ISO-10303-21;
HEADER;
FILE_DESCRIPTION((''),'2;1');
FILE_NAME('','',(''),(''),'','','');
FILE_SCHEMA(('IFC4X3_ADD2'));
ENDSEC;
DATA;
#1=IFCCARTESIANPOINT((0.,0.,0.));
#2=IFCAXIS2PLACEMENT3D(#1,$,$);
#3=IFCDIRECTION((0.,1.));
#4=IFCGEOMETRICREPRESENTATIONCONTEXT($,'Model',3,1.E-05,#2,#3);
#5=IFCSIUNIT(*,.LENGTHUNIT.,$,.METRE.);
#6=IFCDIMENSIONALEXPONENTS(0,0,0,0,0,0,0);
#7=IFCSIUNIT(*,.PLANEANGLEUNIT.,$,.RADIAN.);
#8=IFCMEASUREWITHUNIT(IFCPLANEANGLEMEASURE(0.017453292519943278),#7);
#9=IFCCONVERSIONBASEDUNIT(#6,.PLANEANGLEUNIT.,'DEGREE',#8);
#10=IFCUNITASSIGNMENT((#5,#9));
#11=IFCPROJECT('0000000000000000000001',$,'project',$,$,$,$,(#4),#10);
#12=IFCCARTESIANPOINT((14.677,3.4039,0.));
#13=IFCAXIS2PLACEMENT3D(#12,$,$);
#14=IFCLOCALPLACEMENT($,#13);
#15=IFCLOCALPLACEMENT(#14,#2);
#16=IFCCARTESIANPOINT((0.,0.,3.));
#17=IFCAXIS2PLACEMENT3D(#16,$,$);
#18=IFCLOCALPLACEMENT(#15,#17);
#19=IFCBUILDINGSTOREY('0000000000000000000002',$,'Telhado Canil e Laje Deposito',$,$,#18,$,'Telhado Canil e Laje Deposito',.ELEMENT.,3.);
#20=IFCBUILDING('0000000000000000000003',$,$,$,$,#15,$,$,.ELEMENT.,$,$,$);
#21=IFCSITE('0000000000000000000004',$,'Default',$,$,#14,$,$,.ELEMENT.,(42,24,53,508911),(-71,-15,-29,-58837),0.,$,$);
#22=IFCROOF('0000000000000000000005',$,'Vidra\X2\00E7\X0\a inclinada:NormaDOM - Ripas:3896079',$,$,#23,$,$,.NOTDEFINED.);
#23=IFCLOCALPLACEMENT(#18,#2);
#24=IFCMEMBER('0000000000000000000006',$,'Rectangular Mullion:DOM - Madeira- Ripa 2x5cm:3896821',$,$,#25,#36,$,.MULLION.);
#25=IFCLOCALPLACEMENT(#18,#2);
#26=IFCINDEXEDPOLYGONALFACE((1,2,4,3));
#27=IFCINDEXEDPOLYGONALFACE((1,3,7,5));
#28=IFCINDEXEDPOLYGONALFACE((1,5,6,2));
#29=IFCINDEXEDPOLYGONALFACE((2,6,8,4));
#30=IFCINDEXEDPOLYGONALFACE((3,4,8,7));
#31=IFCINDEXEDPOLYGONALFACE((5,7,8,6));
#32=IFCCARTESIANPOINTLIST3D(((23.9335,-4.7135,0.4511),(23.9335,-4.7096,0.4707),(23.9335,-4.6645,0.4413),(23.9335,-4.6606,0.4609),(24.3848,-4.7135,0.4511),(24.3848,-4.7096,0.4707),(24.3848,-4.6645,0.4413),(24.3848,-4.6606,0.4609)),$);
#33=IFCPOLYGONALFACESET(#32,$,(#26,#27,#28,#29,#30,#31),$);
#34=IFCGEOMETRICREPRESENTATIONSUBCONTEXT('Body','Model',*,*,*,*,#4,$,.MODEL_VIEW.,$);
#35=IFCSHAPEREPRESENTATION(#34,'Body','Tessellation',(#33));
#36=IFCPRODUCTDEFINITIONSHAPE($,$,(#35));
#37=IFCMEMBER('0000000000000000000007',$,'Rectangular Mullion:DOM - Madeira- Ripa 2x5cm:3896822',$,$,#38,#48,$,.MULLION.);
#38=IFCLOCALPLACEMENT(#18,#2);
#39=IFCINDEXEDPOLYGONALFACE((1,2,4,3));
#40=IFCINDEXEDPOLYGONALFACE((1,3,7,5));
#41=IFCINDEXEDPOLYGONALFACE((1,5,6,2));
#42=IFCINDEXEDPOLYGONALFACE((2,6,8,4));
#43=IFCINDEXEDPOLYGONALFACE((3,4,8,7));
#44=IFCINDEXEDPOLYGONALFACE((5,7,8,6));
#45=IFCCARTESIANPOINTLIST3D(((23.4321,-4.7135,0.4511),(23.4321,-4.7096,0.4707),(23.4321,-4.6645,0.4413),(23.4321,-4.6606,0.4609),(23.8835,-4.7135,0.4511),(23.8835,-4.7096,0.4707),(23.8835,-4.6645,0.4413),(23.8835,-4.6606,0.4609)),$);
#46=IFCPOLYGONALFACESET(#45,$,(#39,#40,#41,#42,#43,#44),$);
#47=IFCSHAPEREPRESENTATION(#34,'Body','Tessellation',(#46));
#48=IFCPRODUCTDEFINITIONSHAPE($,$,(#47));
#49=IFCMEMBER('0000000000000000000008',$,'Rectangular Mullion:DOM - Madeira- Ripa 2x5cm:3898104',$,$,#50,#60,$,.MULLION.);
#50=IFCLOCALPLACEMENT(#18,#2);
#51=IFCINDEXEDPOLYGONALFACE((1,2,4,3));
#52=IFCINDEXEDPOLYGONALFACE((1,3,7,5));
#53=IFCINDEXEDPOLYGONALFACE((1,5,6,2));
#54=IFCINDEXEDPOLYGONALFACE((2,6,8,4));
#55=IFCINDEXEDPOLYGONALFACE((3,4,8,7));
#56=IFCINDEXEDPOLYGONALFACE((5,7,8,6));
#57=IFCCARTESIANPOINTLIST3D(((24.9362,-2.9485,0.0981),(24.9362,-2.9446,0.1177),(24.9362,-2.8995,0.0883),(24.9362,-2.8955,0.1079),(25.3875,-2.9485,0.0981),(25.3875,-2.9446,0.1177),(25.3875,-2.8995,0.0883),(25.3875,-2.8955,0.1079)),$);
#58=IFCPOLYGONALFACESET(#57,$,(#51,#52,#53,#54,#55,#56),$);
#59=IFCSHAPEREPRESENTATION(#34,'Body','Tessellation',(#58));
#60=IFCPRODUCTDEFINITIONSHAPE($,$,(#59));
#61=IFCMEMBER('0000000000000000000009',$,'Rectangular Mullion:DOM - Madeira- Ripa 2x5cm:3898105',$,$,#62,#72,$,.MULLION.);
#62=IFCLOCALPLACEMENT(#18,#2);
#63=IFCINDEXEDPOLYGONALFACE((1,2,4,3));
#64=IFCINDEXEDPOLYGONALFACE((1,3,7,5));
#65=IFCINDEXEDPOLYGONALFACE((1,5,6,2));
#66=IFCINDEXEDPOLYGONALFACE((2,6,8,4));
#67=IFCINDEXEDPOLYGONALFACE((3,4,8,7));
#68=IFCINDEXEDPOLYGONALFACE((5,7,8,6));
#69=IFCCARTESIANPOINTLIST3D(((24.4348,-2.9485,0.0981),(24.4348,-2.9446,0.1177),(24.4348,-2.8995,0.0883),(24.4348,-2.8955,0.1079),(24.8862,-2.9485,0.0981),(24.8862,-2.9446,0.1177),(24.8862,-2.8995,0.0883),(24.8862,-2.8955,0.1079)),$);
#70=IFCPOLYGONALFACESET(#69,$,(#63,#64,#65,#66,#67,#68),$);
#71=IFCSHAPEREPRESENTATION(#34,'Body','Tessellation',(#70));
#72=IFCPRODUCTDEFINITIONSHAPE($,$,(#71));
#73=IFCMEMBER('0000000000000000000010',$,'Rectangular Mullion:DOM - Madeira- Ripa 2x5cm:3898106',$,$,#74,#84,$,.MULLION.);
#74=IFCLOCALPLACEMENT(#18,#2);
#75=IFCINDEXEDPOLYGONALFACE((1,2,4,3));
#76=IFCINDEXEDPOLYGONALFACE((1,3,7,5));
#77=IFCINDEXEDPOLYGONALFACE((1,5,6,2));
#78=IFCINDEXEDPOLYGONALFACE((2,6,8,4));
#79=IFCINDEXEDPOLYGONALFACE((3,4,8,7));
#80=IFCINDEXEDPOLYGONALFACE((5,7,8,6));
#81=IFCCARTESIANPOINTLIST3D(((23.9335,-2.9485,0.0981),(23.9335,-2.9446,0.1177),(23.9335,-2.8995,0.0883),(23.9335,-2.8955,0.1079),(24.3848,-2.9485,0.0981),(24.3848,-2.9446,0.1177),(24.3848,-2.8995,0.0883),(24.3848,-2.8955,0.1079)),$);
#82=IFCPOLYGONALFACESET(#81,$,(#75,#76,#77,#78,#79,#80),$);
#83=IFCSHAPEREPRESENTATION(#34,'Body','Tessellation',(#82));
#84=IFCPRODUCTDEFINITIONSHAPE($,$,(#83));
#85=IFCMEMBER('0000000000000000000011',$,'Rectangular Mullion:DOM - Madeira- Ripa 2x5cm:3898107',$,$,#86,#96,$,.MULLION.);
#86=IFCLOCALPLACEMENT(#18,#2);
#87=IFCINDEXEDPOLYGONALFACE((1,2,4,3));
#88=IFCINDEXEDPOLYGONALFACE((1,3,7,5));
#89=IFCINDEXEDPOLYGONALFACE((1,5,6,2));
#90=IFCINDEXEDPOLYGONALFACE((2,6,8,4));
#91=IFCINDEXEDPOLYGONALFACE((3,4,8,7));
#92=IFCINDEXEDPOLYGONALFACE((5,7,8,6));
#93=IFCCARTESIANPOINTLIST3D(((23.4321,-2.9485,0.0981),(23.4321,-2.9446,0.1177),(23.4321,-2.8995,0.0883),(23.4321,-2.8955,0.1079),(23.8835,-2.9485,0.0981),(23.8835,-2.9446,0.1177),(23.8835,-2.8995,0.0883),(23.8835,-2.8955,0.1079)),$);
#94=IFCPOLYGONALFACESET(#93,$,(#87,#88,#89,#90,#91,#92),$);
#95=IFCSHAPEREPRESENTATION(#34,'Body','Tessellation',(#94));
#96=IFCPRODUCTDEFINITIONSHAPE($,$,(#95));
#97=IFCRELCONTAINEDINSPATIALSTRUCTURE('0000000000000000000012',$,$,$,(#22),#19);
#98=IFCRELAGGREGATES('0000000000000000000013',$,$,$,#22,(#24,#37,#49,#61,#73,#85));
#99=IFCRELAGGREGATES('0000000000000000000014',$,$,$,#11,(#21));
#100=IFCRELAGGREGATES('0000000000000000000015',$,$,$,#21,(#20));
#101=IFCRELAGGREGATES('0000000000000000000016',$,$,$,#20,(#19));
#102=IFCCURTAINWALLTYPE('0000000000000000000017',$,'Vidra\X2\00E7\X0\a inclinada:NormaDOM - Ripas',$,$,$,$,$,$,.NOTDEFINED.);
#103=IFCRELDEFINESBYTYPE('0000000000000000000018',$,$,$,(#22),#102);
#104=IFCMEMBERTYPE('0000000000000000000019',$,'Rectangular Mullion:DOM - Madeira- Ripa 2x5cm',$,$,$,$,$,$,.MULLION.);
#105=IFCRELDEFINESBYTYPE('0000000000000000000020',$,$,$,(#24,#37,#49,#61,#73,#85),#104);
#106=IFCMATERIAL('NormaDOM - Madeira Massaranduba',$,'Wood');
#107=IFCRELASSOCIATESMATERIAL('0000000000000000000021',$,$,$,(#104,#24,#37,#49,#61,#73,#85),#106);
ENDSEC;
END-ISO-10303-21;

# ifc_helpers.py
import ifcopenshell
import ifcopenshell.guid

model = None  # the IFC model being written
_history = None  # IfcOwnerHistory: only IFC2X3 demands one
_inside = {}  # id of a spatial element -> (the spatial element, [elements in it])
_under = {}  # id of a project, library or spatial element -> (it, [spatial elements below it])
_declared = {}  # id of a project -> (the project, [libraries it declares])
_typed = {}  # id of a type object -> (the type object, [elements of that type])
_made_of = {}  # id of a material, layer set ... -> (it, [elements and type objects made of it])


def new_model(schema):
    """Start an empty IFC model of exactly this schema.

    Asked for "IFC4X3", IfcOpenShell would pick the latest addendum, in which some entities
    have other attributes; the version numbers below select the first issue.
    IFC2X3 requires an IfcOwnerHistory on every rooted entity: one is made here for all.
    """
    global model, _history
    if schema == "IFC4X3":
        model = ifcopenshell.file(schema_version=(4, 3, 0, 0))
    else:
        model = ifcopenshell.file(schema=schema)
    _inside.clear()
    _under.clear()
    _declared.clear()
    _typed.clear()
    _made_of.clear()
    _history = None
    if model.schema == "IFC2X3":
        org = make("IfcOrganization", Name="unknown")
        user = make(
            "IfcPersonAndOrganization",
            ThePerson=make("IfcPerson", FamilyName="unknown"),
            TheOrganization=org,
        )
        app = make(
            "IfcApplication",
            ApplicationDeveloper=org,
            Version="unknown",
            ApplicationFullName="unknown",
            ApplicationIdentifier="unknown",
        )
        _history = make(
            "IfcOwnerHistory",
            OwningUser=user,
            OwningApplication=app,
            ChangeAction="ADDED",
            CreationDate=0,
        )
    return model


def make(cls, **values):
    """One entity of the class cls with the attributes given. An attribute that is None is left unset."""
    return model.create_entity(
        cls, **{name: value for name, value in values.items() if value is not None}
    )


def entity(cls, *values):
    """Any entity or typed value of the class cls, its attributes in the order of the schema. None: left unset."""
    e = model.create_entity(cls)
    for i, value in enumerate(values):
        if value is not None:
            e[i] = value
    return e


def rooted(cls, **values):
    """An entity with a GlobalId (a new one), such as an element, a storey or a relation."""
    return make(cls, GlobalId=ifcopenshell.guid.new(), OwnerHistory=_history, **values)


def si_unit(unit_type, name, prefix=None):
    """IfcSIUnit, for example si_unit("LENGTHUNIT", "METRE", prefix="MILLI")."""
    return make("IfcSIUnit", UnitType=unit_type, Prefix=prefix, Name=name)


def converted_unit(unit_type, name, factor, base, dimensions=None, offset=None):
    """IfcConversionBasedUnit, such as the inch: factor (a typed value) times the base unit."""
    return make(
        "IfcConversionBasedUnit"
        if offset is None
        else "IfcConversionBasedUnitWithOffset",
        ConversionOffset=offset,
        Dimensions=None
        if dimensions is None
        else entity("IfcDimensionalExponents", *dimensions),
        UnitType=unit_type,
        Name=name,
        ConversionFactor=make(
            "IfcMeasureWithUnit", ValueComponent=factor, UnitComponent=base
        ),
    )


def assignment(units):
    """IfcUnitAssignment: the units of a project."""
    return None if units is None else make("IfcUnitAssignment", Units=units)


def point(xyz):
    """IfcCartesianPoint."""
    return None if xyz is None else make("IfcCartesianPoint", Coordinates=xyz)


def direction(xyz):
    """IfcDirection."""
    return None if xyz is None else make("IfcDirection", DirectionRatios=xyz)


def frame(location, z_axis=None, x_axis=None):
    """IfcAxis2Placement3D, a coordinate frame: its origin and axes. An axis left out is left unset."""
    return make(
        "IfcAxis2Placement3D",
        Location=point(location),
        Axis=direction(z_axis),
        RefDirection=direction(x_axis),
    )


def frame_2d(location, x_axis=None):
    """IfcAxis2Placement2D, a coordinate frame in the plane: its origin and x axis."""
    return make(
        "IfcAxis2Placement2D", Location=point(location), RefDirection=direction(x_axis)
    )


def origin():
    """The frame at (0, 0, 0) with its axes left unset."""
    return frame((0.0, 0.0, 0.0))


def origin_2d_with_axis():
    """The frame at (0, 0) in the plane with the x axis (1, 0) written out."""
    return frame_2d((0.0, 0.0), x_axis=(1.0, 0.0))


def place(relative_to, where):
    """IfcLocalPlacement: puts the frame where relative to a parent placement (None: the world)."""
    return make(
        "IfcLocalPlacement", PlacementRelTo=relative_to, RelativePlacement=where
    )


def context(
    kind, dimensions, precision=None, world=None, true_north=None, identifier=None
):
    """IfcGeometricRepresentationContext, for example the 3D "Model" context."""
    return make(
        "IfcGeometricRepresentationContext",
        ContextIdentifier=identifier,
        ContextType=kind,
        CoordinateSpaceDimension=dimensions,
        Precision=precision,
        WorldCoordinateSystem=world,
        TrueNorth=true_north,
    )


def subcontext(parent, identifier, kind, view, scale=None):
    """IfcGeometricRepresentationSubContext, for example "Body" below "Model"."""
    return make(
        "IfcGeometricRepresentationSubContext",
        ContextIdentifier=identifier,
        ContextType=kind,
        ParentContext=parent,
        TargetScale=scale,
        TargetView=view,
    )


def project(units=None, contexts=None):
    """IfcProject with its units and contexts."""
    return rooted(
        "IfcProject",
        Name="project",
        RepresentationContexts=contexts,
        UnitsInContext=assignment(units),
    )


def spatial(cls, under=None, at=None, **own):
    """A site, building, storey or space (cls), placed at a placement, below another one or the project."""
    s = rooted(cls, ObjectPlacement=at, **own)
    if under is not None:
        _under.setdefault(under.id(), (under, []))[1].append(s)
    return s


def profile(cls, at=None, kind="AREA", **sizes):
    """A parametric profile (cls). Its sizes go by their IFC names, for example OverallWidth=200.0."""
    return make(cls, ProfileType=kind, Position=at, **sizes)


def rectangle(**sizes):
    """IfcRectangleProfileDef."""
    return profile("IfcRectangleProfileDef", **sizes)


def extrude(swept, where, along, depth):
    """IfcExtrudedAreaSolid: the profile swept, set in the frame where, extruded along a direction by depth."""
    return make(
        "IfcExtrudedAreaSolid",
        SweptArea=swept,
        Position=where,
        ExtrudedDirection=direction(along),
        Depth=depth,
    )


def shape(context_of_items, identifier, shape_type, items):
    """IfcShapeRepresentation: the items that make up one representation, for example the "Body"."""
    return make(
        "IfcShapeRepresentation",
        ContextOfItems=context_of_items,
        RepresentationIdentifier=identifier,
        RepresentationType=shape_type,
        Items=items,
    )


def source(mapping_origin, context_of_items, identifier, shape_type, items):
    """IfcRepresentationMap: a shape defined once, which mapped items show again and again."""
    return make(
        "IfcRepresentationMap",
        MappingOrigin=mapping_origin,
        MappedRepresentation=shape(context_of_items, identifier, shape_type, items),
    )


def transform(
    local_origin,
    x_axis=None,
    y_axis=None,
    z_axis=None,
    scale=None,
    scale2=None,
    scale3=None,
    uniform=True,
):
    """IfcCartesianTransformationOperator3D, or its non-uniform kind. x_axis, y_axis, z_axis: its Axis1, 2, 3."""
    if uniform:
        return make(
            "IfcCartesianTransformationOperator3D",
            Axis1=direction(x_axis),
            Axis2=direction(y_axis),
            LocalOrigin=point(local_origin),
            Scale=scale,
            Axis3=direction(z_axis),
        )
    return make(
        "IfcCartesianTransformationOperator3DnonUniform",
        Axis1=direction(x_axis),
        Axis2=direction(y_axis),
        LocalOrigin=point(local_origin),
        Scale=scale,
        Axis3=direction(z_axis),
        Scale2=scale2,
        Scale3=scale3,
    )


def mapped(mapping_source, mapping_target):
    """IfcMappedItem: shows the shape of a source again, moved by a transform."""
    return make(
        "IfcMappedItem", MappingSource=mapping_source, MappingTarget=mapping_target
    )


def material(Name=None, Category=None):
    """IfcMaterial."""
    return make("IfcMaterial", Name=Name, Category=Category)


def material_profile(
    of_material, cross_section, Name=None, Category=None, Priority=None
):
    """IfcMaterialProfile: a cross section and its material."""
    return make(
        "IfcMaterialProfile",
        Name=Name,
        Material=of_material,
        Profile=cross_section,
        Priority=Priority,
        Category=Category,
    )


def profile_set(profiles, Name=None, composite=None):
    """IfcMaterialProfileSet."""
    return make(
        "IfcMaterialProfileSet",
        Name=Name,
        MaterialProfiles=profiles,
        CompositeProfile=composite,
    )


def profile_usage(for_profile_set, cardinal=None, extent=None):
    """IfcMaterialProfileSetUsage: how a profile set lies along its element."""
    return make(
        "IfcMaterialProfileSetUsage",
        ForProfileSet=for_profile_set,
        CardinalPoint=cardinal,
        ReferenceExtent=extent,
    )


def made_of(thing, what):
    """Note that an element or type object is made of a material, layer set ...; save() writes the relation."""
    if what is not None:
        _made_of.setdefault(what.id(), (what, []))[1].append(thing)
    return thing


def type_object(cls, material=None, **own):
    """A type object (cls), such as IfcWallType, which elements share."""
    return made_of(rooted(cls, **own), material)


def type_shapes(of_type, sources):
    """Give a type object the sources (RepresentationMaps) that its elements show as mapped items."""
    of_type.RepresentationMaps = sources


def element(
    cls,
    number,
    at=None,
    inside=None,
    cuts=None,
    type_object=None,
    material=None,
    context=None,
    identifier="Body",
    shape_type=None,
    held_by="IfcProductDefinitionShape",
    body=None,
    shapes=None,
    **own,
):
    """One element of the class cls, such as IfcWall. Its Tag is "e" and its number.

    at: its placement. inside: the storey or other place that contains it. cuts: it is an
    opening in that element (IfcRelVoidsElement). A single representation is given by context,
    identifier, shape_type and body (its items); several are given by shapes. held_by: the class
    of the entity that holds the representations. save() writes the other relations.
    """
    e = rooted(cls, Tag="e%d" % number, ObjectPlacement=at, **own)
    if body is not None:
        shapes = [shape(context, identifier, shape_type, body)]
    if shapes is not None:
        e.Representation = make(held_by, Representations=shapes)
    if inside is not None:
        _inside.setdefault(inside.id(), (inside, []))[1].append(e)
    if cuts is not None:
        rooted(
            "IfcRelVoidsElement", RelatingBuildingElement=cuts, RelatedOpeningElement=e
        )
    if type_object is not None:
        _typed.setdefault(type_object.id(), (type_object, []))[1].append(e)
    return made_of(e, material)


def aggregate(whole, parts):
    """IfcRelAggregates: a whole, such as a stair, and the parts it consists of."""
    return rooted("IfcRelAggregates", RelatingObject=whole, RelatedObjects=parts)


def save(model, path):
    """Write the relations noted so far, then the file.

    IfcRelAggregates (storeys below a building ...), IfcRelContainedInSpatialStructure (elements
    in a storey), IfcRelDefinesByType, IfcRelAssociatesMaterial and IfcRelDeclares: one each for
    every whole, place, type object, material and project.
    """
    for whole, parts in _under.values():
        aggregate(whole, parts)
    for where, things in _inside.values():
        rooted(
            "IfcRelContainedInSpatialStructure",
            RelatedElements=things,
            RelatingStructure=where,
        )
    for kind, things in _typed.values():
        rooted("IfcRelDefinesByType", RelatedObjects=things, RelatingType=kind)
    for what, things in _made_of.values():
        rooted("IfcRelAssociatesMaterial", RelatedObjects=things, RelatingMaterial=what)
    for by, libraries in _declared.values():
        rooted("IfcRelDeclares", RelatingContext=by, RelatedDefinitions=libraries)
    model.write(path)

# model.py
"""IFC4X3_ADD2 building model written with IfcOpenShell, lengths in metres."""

from ifc_helpers import new_model, entity, si_unit, converted_unit, direction, frame, origin, origin_2d_with_axis, place, context, subcontext, project, spatial, rectangle, extrude, source, transform, mapped, material, material_profile, profile_set, profile_usage, type_object, type_shapes, element, aggregate, save


model = new_model("IFC4X3_ADD2")

# Units and contexts
model_context = context("Model", 3, precision=1e-05, world=origin(), true_north=direction((0.0, 1.0)))
body_context = subcontext(model_context, "Body", "Model", "MODEL_VIEW")
ifc_project = project(units=[si_unit("LENGTHUNIT", "METRE"), converted_unit("PLANEANGLEUNIT", "DEGREE", entity("IfcPlaneAngleMeasure", 0.017453292519943278), si_unit("PLANEANGLEUNIT", "RADIAN"), dimensions=[0, 0, 0, 0, 0, 0, 0])], contexts=[model_context])

# Site, building, storey
site_placement = place(None, frame((14.677, 3.4039, 0.0)))
site = spatial("IfcSite", under=ifc_project, at=site_placement, Name="Default", CompositionType="ELEMENT", RefLatitude=(42, 24, 53, 508911), RefLongitude=(-71, -15, -29, -58837), RefElevation=0.0)
building_placement = place(site_placement, origin())
building = spatial("IfcBuilding", under=site, at=building_placement, CompositionType="ELEMENT")
storey_placement = place(building_placement, frame((0.0, 0.0, 3.0)))
storey = spatial("IfcBuildingStorey", under=building, at=storey_placement, Name="Telhado Canil e Laje Deposito", LongName="Telhado Canil e Laje Deposito", CompositionType="ELEMENT", Elevation=3.0)

# Roof
ifc_material = material(Name="NormaDOM - Madeira Massaranduba", Category="Wood")
ifc_material_profile_1 = material_profile(ifc_material, rectangle(XDim=0.05, YDim=0.02, at=origin_2d_with_axis()), Name="DOM - Madeira- Ripa 2x5cm")
ifc_profile_set_1 = profile_set([ifc_material_profile_1], Name="DOM - Madeira- Ripa 2x5cm")
ifc_profile_usage_1 = profile_usage(ifc_profile_set_1)
curtain_wall_type_1 = type_object("IfcCurtainWallType", Name="Vidraça inclinada:NormaDOM - Ripas", PredefinedType="NOTDEFINED")
roof_1_placement = place(storey_placement, frame((0.0, 0.0, -3.0)))
roof_1 = element("IfcRoof", 1, at=roof_1_placement, inside=storey, type_object=curtain_wall_type_1, Name="Vidraça inclinada:NormaDOM - Ripas:3896079", PredefinedType="NOTDEFINED")

# Members
member_type_1 = type_object("IfcMemberType", Name="Rectangular Mullion:DOM - Madeira- Ripa 2x5cm", PredefinedType="MULLION", material=ifc_profile_set_1)
shared_shape_1 = source(origin(), body_context, "Body", "SweptSolid", [
    extrude(rectangle(XDim=0.05, YDim=0.02, at=origin_2d_with_axis()), frame((0.025, 0.01, -0.4514), z_axis=(0.0, 0.0, 1.0), x_axis=(-1.0, 0.0, 0.0)), (0.0, 0.0, 1.0), 0.4514),
])
type_shapes(member_type_1, [shared_shape_1])
member_1_placement = place(roof_1_placement, frame((24.3848, -4.6606, 3.4609), z_axis=(1.0, 0.0, 0.0), x_axis=(0.0, -0.980581, 0.196116)))
member_1 = element("IfcMember", 2, at=member_1_placement, type_object=member_type_1, material=ifc_profile_usage_1, Name="Rectangular Mullion:DOM - Madeira- Ripa 2x5cm:3896821", PredefinedType="MULLION", context=body_context, shape_type="MappedRepresentation", body=[
    mapped(shared_shape_1, transform((0.0, 0.0, 0.0), scale=1.0)),
])
member_2_placement = place(roof_1_placement, frame((23.8835, -4.6606, 3.4609), z_axis=(1.0, 0.0, 0.0), x_axis=(0.0, -0.980581, 0.196116)))
member_2 = element("IfcMember", 3, at=member_2_placement, type_object=member_type_1, material=ifc_profile_usage_1, Name="Rectangular Mullion:DOM - Madeira- Ripa 2x5cm:3896822", PredefinedType="MULLION", context=body_context, shape_type="MappedRepresentation", body=[
    mapped(shared_shape_1, transform((0.0, 0.0, 0.0), scale=1.0)),
])
member_3_placement = place(roof_1_placement, frame((25.3875, -2.8955, 3.1079), z_axis=(1.0, 0.0, 0.0), x_axis=(0.0, -0.980581, 0.196116)))
member_3 = element("IfcMember", 4, at=member_3_placement, type_object=member_type_1, material=ifc_profile_usage_1, Name="Rectangular Mullion:DOM - Madeira- Ripa 2x5cm:3898104", PredefinedType="MULLION", context=body_context, shape_type="MappedRepresentation", body=[
    mapped(shared_shape_1, transform((0.0, 0.0, 0.0), scale=1.0)),
])
member_4_placement = place(roof_1_placement, frame((24.8862, -2.8955, 3.1079), z_axis=(1.0, 0.0, 0.0), x_axis=(0.0, -0.980581, 0.196116)))
member_4 = element("IfcMember", 5, at=member_4_placement, type_object=member_type_1, material=ifc_profile_usage_1, Name="Rectangular Mullion:DOM - Madeira- Ripa 2x5cm:3898105", PredefinedType="MULLION", context=body_context, shape_type="MappedRepresentation", body=[
    mapped(shared_shape_1, transform((0.0, 0.0, 0.0), scale=1.0)),
])
member_5_placement = place(roof_1_placement, frame((24.3848, -2.8955, 3.1079), z_axis=(1.0, 0.0, 0.0), x_axis=(0.0, -0.980581, 0.196116)))
member_5 = element("IfcMember", 6, at=member_5_placement, type_object=member_type_1, material=ifc_profile_usage_1, Name="Rectangular Mullion:DOM - Madeira- Ripa 2x5cm:3898106", PredefinedType="MULLION", context=body_context, shape_type="MappedRepresentation", body=[
    mapped(shared_shape_1, transform((0.0, 0.0, 0.0), scale=1.0)),
])
member_6_placement = place(roof_1_placement, frame((23.8835, -2.8955, 3.1079), z_axis=(1.0, 0.0, 0.0), x_axis=(0.0, -0.980581, 0.196116)))
member_6 = element("IfcMember", 7, at=member_6_placement, type_object=member_type_1, material=ifc_profile_usage_1, Name="Rectangular Mullion:DOM - Madeira- Ripa 2x5cm:3898107", PredefinedType="MULLION", context=body_context, shape_type="MappedRepresentation", body=[
    mapped(shared_shape_1, transform((0.0, 0.0, 0.0), scale=1.0)),
])
aggregate(roof_1, [member_1, member_2, member_3, member_4, member_5, member_6])

save(model, "model.ifc")
